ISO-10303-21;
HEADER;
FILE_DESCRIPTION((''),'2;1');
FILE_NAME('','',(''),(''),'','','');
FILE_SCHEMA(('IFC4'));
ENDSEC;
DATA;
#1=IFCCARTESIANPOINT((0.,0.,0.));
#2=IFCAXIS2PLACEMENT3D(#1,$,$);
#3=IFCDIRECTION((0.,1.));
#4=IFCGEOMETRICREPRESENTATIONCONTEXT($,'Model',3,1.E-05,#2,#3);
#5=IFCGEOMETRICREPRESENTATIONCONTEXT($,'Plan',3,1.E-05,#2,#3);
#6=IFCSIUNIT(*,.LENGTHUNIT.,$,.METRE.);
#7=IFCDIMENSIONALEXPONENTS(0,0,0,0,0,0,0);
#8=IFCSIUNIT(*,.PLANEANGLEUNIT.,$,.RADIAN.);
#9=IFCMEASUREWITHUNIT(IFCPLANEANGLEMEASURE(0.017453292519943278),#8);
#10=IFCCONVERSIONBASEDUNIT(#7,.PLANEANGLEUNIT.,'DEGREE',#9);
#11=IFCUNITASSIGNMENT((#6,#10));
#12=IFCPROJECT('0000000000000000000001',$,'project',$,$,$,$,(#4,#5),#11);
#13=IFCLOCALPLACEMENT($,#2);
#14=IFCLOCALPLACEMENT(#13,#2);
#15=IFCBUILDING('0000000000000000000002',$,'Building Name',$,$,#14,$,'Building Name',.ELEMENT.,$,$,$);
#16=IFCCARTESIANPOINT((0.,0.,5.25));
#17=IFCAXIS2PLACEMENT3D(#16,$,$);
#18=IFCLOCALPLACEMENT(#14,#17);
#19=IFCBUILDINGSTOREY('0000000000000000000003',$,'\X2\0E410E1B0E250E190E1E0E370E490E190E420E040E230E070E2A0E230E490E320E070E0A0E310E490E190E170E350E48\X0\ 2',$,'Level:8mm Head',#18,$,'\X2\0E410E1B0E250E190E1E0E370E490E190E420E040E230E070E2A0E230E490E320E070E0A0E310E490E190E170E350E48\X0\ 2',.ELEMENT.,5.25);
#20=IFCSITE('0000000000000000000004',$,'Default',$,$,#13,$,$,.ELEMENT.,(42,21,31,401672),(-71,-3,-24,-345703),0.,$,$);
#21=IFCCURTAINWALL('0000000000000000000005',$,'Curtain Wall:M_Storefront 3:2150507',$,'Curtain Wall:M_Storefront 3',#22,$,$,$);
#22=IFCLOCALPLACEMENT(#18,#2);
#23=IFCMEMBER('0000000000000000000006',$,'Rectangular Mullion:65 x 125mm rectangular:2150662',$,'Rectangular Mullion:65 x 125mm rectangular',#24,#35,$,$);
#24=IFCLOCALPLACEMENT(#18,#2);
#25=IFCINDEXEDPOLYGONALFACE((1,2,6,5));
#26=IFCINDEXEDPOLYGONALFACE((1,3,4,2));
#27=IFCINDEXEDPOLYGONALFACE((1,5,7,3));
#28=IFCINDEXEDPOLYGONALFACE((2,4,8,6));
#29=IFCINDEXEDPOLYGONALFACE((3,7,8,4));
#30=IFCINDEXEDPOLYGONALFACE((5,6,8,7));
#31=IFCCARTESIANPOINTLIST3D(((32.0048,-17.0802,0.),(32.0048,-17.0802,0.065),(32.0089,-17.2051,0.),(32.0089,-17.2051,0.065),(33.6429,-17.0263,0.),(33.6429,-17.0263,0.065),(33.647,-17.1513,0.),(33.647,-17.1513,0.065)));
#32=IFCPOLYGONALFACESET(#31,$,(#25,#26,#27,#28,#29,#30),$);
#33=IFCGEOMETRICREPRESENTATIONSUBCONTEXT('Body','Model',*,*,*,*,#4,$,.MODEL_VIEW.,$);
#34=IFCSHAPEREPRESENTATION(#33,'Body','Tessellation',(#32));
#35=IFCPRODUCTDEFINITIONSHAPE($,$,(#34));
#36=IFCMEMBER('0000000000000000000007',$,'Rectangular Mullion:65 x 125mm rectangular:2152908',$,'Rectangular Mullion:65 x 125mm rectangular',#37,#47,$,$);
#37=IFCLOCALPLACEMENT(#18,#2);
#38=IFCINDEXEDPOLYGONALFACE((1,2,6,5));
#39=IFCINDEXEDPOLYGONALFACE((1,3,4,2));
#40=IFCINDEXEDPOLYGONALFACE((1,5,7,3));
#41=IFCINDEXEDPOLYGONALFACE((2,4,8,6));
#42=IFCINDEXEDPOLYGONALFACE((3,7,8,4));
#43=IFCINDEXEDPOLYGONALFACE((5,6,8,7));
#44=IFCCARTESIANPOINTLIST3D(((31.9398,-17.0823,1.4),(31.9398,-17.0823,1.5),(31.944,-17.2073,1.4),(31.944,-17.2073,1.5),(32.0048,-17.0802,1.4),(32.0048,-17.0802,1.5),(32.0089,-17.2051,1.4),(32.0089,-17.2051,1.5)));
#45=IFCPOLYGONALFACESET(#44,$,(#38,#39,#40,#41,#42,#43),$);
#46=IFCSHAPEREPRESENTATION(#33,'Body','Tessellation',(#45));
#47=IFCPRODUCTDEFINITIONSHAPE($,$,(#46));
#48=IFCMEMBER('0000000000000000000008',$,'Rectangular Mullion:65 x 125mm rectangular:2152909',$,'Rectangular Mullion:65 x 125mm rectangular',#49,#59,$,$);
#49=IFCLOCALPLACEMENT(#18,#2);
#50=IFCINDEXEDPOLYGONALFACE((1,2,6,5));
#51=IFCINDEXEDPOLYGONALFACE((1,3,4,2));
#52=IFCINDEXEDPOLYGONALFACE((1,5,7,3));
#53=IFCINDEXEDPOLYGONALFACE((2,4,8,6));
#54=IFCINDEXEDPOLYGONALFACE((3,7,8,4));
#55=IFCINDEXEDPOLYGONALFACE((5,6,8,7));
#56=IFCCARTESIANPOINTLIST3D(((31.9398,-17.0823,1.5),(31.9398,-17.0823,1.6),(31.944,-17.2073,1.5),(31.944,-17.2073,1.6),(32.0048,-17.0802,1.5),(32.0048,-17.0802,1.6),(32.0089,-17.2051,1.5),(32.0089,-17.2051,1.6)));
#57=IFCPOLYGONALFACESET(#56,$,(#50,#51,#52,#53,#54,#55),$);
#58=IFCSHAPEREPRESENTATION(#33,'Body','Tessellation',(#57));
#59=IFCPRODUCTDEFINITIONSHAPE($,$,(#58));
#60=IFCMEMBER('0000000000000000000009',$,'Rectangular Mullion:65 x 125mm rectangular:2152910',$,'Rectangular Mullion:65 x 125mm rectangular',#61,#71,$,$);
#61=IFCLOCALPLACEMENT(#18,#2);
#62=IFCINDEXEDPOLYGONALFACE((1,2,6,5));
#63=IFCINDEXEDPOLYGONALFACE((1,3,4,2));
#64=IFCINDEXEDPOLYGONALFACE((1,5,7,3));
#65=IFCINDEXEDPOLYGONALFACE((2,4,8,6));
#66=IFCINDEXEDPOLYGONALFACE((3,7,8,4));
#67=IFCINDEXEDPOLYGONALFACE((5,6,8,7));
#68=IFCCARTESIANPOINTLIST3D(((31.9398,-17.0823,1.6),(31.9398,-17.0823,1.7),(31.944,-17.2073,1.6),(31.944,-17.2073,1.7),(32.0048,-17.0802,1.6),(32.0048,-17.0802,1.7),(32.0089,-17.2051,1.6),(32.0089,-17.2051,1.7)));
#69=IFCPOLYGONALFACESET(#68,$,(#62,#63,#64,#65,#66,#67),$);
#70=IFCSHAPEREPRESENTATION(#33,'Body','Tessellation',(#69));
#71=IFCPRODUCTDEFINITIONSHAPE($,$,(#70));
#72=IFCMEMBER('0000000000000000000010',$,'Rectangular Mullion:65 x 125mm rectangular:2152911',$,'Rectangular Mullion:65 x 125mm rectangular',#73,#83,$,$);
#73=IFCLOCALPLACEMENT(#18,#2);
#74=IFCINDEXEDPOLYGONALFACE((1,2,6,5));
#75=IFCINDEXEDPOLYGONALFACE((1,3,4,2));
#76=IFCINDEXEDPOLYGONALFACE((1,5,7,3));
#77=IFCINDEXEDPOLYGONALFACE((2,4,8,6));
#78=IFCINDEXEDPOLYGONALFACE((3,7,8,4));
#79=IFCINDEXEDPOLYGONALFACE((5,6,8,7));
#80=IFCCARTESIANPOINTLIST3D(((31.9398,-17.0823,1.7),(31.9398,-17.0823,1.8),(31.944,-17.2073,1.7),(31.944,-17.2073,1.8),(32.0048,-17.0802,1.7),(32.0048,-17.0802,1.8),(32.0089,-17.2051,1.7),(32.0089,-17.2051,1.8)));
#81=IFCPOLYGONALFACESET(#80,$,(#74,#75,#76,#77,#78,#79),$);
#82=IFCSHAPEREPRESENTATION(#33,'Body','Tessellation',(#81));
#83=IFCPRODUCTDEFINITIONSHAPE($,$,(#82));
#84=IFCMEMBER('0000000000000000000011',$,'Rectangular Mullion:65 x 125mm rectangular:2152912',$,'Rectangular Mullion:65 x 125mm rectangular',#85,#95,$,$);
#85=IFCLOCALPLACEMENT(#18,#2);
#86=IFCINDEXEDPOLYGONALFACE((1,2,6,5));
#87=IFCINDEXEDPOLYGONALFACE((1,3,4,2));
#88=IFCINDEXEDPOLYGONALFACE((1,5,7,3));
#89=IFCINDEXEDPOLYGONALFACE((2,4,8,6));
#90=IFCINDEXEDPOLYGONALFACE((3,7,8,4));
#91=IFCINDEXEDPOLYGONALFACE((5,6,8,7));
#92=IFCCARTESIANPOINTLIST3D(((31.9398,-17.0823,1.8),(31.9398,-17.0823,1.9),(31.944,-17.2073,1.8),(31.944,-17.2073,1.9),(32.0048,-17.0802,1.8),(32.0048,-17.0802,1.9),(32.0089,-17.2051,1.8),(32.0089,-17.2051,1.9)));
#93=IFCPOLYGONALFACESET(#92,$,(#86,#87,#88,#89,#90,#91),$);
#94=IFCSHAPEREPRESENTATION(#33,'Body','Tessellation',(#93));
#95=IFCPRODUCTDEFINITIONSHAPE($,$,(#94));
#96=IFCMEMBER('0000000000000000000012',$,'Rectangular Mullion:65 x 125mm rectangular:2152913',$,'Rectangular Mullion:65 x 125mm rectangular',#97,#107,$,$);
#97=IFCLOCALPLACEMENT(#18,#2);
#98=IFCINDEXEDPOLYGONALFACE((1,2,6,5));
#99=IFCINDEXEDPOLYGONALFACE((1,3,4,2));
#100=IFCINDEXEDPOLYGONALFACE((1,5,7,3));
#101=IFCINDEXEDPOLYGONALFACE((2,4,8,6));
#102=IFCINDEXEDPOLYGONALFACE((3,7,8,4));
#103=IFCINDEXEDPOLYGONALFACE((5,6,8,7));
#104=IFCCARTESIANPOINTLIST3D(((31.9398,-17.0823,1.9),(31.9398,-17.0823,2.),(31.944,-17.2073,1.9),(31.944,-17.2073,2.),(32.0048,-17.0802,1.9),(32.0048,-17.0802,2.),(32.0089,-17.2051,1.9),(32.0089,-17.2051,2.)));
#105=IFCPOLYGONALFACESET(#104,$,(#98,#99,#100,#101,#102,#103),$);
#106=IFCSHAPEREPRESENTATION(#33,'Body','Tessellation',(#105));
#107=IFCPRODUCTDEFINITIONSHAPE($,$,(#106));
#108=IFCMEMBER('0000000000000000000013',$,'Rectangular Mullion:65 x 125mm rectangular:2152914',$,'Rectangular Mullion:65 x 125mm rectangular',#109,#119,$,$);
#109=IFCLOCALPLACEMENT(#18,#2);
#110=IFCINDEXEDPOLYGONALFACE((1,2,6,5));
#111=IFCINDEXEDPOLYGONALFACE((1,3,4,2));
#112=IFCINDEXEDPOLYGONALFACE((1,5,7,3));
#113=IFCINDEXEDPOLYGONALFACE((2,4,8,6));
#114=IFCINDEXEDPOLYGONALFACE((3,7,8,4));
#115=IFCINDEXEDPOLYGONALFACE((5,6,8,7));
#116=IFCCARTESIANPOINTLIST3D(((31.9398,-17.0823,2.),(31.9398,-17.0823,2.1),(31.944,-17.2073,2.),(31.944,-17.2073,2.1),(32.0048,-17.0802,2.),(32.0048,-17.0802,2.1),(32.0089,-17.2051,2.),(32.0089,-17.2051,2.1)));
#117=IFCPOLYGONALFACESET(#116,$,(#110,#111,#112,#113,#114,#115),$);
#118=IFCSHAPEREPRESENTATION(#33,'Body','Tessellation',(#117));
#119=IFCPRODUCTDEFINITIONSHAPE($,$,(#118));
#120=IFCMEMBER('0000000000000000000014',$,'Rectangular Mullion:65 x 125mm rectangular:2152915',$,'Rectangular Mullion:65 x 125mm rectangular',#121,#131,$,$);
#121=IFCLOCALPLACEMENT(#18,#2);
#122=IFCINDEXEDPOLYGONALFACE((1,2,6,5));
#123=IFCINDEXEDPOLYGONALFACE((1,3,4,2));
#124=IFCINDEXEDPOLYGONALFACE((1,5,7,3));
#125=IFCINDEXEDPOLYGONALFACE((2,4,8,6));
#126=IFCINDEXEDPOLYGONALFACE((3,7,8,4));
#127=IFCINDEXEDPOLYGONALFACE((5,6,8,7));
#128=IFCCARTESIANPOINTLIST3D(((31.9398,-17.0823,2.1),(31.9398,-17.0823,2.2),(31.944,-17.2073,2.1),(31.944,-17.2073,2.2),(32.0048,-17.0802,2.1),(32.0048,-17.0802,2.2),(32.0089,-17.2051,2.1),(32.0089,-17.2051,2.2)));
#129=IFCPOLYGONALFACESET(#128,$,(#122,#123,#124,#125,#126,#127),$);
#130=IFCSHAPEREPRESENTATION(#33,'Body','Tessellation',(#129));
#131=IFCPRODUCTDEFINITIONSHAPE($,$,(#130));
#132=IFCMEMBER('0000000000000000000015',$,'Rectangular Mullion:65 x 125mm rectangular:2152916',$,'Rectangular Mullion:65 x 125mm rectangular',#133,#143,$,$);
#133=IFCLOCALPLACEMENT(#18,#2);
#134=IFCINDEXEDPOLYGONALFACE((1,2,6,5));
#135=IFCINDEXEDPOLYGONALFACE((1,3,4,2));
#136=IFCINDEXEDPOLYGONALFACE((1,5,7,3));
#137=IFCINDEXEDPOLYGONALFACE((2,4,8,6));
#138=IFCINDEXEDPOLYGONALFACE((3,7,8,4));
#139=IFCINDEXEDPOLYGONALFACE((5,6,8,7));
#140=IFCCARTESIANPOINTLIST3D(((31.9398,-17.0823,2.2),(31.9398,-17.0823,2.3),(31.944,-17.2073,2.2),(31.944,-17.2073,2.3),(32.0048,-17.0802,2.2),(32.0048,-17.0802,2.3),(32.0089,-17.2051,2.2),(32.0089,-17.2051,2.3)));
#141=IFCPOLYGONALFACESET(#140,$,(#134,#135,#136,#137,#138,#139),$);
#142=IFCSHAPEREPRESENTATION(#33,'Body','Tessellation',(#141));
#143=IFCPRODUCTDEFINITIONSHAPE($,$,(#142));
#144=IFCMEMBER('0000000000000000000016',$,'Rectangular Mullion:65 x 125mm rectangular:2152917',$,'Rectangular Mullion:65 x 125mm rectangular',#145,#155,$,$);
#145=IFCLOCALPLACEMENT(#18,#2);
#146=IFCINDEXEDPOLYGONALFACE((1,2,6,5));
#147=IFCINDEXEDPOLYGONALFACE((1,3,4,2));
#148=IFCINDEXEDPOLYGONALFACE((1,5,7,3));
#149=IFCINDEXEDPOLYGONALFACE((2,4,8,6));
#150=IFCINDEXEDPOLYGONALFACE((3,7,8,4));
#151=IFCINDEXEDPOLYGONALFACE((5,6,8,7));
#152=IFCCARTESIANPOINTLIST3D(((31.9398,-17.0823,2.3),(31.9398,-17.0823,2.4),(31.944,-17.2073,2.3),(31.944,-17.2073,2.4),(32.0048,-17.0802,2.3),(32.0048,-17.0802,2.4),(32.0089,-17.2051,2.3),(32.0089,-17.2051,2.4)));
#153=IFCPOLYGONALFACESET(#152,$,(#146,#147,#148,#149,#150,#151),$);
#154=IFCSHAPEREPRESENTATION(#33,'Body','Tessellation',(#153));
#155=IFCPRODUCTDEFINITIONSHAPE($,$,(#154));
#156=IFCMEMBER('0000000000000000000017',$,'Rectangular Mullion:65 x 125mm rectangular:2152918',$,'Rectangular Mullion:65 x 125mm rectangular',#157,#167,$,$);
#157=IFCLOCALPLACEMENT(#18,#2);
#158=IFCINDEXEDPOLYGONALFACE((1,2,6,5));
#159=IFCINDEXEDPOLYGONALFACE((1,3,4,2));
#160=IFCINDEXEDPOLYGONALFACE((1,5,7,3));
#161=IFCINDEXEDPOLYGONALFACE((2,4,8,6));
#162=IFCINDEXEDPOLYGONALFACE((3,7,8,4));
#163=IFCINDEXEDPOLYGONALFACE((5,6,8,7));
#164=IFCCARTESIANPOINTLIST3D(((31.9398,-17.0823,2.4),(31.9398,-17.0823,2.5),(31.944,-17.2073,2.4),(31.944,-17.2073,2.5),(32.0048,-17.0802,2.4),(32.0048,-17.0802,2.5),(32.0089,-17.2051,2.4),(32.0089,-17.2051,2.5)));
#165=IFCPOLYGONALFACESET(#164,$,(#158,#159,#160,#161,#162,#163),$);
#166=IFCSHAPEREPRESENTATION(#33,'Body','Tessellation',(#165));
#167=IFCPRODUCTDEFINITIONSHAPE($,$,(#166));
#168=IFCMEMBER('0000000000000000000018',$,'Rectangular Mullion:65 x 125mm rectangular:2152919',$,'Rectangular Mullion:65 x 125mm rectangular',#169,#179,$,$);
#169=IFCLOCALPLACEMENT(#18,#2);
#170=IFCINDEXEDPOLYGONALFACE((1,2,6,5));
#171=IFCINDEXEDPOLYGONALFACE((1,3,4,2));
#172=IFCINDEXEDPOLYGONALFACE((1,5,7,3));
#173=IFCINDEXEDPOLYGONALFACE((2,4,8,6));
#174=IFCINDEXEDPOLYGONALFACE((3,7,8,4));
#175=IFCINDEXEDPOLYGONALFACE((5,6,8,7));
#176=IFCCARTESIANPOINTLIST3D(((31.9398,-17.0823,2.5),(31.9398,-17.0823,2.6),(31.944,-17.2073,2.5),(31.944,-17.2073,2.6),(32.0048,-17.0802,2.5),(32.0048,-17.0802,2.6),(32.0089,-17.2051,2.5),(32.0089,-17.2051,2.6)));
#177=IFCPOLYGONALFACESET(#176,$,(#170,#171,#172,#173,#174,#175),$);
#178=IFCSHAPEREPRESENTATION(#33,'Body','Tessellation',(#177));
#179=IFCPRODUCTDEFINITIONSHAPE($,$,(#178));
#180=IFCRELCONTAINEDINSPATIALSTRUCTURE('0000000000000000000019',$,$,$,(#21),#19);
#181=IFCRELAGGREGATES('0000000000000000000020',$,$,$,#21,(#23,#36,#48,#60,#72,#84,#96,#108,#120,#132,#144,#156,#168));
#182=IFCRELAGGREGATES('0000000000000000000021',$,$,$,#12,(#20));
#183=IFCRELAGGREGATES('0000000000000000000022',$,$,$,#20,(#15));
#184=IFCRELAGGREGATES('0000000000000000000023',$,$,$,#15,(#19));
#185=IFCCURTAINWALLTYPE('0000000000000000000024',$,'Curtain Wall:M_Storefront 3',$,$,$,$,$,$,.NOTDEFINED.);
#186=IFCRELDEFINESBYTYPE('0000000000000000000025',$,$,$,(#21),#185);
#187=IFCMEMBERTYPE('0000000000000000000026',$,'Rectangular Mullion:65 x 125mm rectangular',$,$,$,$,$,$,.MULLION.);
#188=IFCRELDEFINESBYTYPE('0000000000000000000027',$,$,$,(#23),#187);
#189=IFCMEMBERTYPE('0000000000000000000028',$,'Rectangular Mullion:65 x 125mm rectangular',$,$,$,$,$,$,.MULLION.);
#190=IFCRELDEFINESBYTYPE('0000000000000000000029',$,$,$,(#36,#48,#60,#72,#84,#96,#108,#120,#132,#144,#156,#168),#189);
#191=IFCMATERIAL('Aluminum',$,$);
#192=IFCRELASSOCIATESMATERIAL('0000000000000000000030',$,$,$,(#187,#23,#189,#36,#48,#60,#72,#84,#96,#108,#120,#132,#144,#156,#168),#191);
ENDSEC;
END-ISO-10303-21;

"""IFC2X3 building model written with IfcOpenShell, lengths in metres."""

from ifc_helpers import new_model, entity, si_unit, converted_unit, direction, frame, origin, origin_2d_with_axis, place, context, subcontext, project, spatial, rectangle, extrude, source, transform, mapped, material, type_object, type_shapes, element, aggregate, save


model = new_model("IFC2X3")

# Units and contexts
model_context = context("Model", 3, precision=1e-05, world=origin(), true_north=direction((0.0, 1.0)))
plan_context = context("Plan", 3, precision=1e-05, world=origin(), true_north=direction((0.0, 1.0)))
body_context = subcontext(model_context, "Body", "Model", "MODEL_VIEW")
ifc_project = project(units=[si_unit("LENGTHUNIT", "METRE"), converted_unit("PLANEANGLEUNIT", "DEGREE", entity("IfcPlaneAngleMeasure", 0.017453292519943278), si_unit("PLANEANGLEUNIT", "RADIAN"), dimensions=[0, 0, 0, 0, 0, 0, 0])], contexts=[model_context, plan_context])

# Site, building, storey
site_placement = place(None, origin())
site = spatial("IfcSite", under=ifc_project, at=site_placement, Name="Default", CompositionType="ELEMENT", RefLatitude=(42, 21, 31, 401672), RefLongitude=(-71, -3, -24, -345703), RefElevation=0.0)
building_placement = place(site_placement, origin())
building = spatial("IfcBuilding", under=site, at=building_placement, Name="Building Name", LongName="Building Name", CompositionType="ELEMENT")
storey_placement = place(building_placement, frame((0.0, 0.0, 5.25)))
storey = spatial("IfcBuildingStorey", under=building, at=storey_placement, Name="แปลนพื้นโครงสร้างชั้นที่ 2", ObjectType="Level:8mm Head", LongName="แปลนพื้นโครงสร้างชั้นที่ 2", CompositionType="ELEMENT", Elevation=5.25)

# Curtain wall, members
curtain_wall_type = type_object("IfcCurtainWallType", Name="Curtain Wall:M_Storefront 3", PredefinedType="NOTDEFINED")
curtain_wall_placement = place(storey_placement, frame((0.0, 0.0, -5.25)))
curtain_wall = element("IfcCurtainWall", 1, at=curtain_wall_placement, inside=storey, type_object=curtain_wall_type, Name="Curtain Wall:M_Storefront 3:2150507", ObjectType="Curtain Wall:M_Storefront 3")
ifc_material_1 = material(Name="Aluminum")
member_type_1 = type_object("IfcMemberType", Name="Rectangular Mullion:65 x 125mm rectangular", PredefinedType="MULLION", material=ifc_material_1)
shared_shape_1 = source(origin(), body_context, "Body", "SweptSolid", [
    extrude(rectangle(XDim=0.065, YDim=0.125, at=origin_2d_with_axis()), frame((-0.0325, 0.0, -1.6389), z_axis=(0.0, 0.0, 1.0), x_axis=(-1.0, 0.0, 0.0)), (0.0, 0.0, 1.0), 1.6389),
])
type_shapes(member_type_1, [shared_shape_1])
member_1_placement = place(curtain_wall_placement, frame((32.0069, -17.1427, 5.25), z_axis=(-0.99946, -0.032862, 0.0), x_axis=(0.0, 0.0, -1.0)))
member_1 = element("IfcMember", 2, at=member_1_placement, type_object=member_type_1, material=ifc_material_1, Name="Rectangular Mullion:65 x 125mm rectangular:2150662", ObjectType="Rectangular Mullion:65 x 125mm rectangular", context=body_context, shape_type="MappedRepresentation", body=[
    mapped(shared_shape_1, transform((0.0, 0.0, 0.0), scale=1.0)),
])
member_type_2 = type_object("IfcMemberType", Name="Rectangular Mullion:65 x 125mm rectangular", PredefinedType="MULLION", material=ifc_material_1)
shared_shape_2 = source(origin(), body_context, "Body", "SweptSolid", [
    extrude(rectangle(XDim=0.065, YDim=0.125, at=origin_2d_with_axis()), frame((-0.0325, 0.0, -0.1), z_axis=(0.0, 0.0, 1.0), x_axis=(-1.0, 0.0, 0.0)), (0.0, 0.0, 1.0), 0.1),
])
type_shapes(member_type_2, [shared_shape_2])
member_2_placement = place(curtain_wall_placement, frame((31.9419, -17.1448, 6.75), z_axis=(0.0, 0.0, 1.0), x_axis=(-0.99946, -0.032862, 0.0)))
member_2 = element("IfcMember", 3, at=member_2_placement, type_object=member_type_2, material=ifc_material_1, Name="Rectangular Mullion:65 x 125mm rectangular:2152908", ObjectType="Rectangular Mullion:65 x 125mm rectangular", context=body_context, shape_type="MappedRepresentation", body=[
    mapped(shared_shape_2, transform((0.0, 0.0, 0.0), scale=1.0)),
])
member_3_placement = place(curtain_wall_placement, frame((31.9419, -17.1448, 6.85), z_axis=(0.0, 0.0, 1.0), x_axis=(-0.99946, -0.032862, 0.0)))
member_3 = element("IfcMember", 4, at=member_3_placement, type_object=member_type_2, material=ifc_material_1, Name="Rectangular Mullion:65 x 125mm rectangular:2152909", ObjectType="Rectangular Mullion:65 x 125mm rectangular", context=body_context, shape_type="MappedRepresentation", body=[
    mapped(shared_shape_2, transform((0.0, 0.0, 0.0), scale=1.0)),
])
member_4_placement = place(curtain_wall_placement, frame((31.9419, -17.1448, 6.95), z_axis=(0.0, 0.0, 1.0), x_axis=(-0.99946, -0.032862, 0.0)))
member_4 = element("IfcMember", 5, at=member_4_placement, type_object=member_type_2, material=ifc_material_1, Name="Rectangular Mullion:65 x 125mm rectangular:2152910", ObjectType="Rectangular Mullion:65 x 125mm rectangular", context=body_context, shape_type="MappedRepresentation", body=[
    mapped(shared_shape_2, transform((0.0, 0.0, 0.0), scale=1.0)),
])
member_5_placement = place(curtain_wall_placement, frame((31.9419, -17.1448, 7.05), z_axis=(0.0, 0.0, 1.0), x_axis=(-0.99946, -0.032862, 0.0)))
member_5 = element("IfcMember", 6, at=member_5_placement, type_object=member_type_2, material=ifc_material_1, Name="Rectangular Mullion:65 x 125mm rectangular:2152911", ObjectType="Rectangular Mullion:65 x 125mm rectangular", context=body_context, shape_type="MappedRepresentation", body=[
    mapped(shared_shape_2, transform((0.0, 0.0, 0.0), scale=1.0)),
])
member_6_placement = place(curtain_wall_placement, frame((31.9419, -17.1448, 7.15), z_axis=(0.0, 0.0, 1.0), x_axis=(-0.99946, -0.032862, 0.0)))
member_6 = element("IfcMember", 7, at=member_6_placement, type_object=member_type_2, material=ifc_material_1, Name="Rectangular Mullion:65 x 125mm rectangular:2152912", ObjectType="Rectangular Mullion:65 x 125mm rectangular", context=body_context, shape_type="MappedRepresentation", body=[
    mapped(shared_shape_2, transform((0.0, 0.0, 0.0), scale=1.0)),
])
member_7_placement = place(curtain_wall_placement, frame((31.9419, -17.1448, 7.25), z_axis=(0.0, 0.0, 1.0), x_axis=(-0.99946, -0.032862, 0.0)))
member_7 = element("IfcMember", 8, at=member_7_placement, type_object=member_type_2, material=ifc_material_1, Name="Rectangular Mullion:65 x 125mm rectangular:2152913", ObjectType="Rectangular Mullion:65 x 125mm rectangular", context=body_context, shape_type="MappedRepresentation", body=[
    mapped(shared_shape_2, transform((0.0, 0.0, 0.0), scale=1.0)),
])
member_8_placement = place(curtain_wall_placement, frame((31.9419, -17.1448, 7.35), z_axis=(0.0, 0.0, 1.0), x_axis=(-0.99946, -0.032862, 0.0)))
member_8 = element("IfcMember", 9, at=member_8_placement, type_object=member_type_2, material=ifc_material_1, Name="Rectangular Mullion:65 x 125mm rectangular:2152914", ObjectType="Rectangular Mullion:65 x 125mm rectangular", context=body_context, shape_type="MappedRepresentation", body=[
    mapped(shared_shape_2, transform((0.0, 0.0, 0.0), scale=1.0)),
])
member_9_placement = place(curtain_wall_placement, frame((31.9419, -17.1448, 7.45), z_axis=(0.0, 0.0, 1.0), x_axis=(-0.99946, -0.032862, 0.0)))
member_9 = element("IfcMember", 10, at=member_9_placement, type_object=member_type_2, material=ifc_material_1, Name="Rectangular Mullion:65 x 125mm rectangular:2152915", ObjectType="Rectangular Mullion:65 x 125mm rectangular", context=body_context, shape_type="MappedRepresentation", body=[
    mapped(shared_shape_2, transform((0.0, 0.0, 0.0), scale=1.0)),
])
member_10_placement = place(curtain_wall_placement, frame((31.9419, -17.1448, 7.55), z_axis=(0.0, 0.0, 1.0), x_axis=(-0.99946, -0.032862, 0.0)))
member_10 = element("IfcMember", 11, at=member_10_placement, type_object=member_type_2, material=ifc_material_1, Name="Rectangular Mullion:65 x 125mm rectangular:2152916", ObjectType="Rectangular Mullion:65 x 125mm rectangular", context=body_context, shape_type="MappedRepresentation", body=[
    mapped(shared_shape_2, transform((0.0, 0.0, 0.0), scale=1.0)),
])
member_11_placement = place(curtain_wall_placement, frame((31.9419, -17.1448, 7.65), z_axis=(0.0, 0.0, 1.0), x_axis=(-0.99946, -0.032862, 0.0)))
member_11 = element("IfcMember", 12, at=member_11_placement, type_object=member_type_2, material=ifc_material_1, Name="Rectangular Mullion:65 x 125mm rectangular:2152917", ObjectType="Rectangular Mullion:65 x 125mm rectangular", context=body_context, shape_type="MappedRepresentation", body=[
    mapped(shared_shape_2, transform((0.0, 0.0, 0.0), scale=1.0)),
])
member_12_placement = place(curtain_wall_placement, frame((31.9419, -17.1448, 7.75), z_axis=(0.0, 0.0, 1.0), x_axis=(-0.99946, -0.032862, 0.0)))
member_12 = element("IfcMember", 13, at=member_12_placement, type_object=member_type_2, material=ifc_material_1, Name="Rectangular Mullion:65 x 125mm rectangular:2152918", ObjectType="Rectangular Mullion:65 x 125mm rectangular", context=body_context, shape_type="MappedRepresentation", body=[
    mapped(shared_shape_2, transform((0.0, 0.0, 0.0), scale=1.0)),
])
member_13_placement = place(curtain_wall_placement, frame((31.9419, -17.1448, 7.85), z_axis=(0.0, 0.0, 1.0), x_axis=(-0.99946, -0.032862, 0.0)))
member_13 = element("IfcMember", 14, at=member_13_placement, type_object=member_type_2, material=ifc_material_1, Name="Rectangular Mullion:65 x 125mm rectangular:2152919", ObjectType="Rectangular Mullion:65 x 125mm rectangular", context=body_context, shape_type="MappedRepresentation", body=[
    mapped(shared_shape_2, transform((0.0, 0.0, 0.0), scale=1.0)),
])
aggregate(curtain_wall, [member_1, member_2, member_3, member_4, member_5, member_6, member_7, member_8, member_9, member_10, member_11, member_12, member_13])

save(model, "model.ifc")
